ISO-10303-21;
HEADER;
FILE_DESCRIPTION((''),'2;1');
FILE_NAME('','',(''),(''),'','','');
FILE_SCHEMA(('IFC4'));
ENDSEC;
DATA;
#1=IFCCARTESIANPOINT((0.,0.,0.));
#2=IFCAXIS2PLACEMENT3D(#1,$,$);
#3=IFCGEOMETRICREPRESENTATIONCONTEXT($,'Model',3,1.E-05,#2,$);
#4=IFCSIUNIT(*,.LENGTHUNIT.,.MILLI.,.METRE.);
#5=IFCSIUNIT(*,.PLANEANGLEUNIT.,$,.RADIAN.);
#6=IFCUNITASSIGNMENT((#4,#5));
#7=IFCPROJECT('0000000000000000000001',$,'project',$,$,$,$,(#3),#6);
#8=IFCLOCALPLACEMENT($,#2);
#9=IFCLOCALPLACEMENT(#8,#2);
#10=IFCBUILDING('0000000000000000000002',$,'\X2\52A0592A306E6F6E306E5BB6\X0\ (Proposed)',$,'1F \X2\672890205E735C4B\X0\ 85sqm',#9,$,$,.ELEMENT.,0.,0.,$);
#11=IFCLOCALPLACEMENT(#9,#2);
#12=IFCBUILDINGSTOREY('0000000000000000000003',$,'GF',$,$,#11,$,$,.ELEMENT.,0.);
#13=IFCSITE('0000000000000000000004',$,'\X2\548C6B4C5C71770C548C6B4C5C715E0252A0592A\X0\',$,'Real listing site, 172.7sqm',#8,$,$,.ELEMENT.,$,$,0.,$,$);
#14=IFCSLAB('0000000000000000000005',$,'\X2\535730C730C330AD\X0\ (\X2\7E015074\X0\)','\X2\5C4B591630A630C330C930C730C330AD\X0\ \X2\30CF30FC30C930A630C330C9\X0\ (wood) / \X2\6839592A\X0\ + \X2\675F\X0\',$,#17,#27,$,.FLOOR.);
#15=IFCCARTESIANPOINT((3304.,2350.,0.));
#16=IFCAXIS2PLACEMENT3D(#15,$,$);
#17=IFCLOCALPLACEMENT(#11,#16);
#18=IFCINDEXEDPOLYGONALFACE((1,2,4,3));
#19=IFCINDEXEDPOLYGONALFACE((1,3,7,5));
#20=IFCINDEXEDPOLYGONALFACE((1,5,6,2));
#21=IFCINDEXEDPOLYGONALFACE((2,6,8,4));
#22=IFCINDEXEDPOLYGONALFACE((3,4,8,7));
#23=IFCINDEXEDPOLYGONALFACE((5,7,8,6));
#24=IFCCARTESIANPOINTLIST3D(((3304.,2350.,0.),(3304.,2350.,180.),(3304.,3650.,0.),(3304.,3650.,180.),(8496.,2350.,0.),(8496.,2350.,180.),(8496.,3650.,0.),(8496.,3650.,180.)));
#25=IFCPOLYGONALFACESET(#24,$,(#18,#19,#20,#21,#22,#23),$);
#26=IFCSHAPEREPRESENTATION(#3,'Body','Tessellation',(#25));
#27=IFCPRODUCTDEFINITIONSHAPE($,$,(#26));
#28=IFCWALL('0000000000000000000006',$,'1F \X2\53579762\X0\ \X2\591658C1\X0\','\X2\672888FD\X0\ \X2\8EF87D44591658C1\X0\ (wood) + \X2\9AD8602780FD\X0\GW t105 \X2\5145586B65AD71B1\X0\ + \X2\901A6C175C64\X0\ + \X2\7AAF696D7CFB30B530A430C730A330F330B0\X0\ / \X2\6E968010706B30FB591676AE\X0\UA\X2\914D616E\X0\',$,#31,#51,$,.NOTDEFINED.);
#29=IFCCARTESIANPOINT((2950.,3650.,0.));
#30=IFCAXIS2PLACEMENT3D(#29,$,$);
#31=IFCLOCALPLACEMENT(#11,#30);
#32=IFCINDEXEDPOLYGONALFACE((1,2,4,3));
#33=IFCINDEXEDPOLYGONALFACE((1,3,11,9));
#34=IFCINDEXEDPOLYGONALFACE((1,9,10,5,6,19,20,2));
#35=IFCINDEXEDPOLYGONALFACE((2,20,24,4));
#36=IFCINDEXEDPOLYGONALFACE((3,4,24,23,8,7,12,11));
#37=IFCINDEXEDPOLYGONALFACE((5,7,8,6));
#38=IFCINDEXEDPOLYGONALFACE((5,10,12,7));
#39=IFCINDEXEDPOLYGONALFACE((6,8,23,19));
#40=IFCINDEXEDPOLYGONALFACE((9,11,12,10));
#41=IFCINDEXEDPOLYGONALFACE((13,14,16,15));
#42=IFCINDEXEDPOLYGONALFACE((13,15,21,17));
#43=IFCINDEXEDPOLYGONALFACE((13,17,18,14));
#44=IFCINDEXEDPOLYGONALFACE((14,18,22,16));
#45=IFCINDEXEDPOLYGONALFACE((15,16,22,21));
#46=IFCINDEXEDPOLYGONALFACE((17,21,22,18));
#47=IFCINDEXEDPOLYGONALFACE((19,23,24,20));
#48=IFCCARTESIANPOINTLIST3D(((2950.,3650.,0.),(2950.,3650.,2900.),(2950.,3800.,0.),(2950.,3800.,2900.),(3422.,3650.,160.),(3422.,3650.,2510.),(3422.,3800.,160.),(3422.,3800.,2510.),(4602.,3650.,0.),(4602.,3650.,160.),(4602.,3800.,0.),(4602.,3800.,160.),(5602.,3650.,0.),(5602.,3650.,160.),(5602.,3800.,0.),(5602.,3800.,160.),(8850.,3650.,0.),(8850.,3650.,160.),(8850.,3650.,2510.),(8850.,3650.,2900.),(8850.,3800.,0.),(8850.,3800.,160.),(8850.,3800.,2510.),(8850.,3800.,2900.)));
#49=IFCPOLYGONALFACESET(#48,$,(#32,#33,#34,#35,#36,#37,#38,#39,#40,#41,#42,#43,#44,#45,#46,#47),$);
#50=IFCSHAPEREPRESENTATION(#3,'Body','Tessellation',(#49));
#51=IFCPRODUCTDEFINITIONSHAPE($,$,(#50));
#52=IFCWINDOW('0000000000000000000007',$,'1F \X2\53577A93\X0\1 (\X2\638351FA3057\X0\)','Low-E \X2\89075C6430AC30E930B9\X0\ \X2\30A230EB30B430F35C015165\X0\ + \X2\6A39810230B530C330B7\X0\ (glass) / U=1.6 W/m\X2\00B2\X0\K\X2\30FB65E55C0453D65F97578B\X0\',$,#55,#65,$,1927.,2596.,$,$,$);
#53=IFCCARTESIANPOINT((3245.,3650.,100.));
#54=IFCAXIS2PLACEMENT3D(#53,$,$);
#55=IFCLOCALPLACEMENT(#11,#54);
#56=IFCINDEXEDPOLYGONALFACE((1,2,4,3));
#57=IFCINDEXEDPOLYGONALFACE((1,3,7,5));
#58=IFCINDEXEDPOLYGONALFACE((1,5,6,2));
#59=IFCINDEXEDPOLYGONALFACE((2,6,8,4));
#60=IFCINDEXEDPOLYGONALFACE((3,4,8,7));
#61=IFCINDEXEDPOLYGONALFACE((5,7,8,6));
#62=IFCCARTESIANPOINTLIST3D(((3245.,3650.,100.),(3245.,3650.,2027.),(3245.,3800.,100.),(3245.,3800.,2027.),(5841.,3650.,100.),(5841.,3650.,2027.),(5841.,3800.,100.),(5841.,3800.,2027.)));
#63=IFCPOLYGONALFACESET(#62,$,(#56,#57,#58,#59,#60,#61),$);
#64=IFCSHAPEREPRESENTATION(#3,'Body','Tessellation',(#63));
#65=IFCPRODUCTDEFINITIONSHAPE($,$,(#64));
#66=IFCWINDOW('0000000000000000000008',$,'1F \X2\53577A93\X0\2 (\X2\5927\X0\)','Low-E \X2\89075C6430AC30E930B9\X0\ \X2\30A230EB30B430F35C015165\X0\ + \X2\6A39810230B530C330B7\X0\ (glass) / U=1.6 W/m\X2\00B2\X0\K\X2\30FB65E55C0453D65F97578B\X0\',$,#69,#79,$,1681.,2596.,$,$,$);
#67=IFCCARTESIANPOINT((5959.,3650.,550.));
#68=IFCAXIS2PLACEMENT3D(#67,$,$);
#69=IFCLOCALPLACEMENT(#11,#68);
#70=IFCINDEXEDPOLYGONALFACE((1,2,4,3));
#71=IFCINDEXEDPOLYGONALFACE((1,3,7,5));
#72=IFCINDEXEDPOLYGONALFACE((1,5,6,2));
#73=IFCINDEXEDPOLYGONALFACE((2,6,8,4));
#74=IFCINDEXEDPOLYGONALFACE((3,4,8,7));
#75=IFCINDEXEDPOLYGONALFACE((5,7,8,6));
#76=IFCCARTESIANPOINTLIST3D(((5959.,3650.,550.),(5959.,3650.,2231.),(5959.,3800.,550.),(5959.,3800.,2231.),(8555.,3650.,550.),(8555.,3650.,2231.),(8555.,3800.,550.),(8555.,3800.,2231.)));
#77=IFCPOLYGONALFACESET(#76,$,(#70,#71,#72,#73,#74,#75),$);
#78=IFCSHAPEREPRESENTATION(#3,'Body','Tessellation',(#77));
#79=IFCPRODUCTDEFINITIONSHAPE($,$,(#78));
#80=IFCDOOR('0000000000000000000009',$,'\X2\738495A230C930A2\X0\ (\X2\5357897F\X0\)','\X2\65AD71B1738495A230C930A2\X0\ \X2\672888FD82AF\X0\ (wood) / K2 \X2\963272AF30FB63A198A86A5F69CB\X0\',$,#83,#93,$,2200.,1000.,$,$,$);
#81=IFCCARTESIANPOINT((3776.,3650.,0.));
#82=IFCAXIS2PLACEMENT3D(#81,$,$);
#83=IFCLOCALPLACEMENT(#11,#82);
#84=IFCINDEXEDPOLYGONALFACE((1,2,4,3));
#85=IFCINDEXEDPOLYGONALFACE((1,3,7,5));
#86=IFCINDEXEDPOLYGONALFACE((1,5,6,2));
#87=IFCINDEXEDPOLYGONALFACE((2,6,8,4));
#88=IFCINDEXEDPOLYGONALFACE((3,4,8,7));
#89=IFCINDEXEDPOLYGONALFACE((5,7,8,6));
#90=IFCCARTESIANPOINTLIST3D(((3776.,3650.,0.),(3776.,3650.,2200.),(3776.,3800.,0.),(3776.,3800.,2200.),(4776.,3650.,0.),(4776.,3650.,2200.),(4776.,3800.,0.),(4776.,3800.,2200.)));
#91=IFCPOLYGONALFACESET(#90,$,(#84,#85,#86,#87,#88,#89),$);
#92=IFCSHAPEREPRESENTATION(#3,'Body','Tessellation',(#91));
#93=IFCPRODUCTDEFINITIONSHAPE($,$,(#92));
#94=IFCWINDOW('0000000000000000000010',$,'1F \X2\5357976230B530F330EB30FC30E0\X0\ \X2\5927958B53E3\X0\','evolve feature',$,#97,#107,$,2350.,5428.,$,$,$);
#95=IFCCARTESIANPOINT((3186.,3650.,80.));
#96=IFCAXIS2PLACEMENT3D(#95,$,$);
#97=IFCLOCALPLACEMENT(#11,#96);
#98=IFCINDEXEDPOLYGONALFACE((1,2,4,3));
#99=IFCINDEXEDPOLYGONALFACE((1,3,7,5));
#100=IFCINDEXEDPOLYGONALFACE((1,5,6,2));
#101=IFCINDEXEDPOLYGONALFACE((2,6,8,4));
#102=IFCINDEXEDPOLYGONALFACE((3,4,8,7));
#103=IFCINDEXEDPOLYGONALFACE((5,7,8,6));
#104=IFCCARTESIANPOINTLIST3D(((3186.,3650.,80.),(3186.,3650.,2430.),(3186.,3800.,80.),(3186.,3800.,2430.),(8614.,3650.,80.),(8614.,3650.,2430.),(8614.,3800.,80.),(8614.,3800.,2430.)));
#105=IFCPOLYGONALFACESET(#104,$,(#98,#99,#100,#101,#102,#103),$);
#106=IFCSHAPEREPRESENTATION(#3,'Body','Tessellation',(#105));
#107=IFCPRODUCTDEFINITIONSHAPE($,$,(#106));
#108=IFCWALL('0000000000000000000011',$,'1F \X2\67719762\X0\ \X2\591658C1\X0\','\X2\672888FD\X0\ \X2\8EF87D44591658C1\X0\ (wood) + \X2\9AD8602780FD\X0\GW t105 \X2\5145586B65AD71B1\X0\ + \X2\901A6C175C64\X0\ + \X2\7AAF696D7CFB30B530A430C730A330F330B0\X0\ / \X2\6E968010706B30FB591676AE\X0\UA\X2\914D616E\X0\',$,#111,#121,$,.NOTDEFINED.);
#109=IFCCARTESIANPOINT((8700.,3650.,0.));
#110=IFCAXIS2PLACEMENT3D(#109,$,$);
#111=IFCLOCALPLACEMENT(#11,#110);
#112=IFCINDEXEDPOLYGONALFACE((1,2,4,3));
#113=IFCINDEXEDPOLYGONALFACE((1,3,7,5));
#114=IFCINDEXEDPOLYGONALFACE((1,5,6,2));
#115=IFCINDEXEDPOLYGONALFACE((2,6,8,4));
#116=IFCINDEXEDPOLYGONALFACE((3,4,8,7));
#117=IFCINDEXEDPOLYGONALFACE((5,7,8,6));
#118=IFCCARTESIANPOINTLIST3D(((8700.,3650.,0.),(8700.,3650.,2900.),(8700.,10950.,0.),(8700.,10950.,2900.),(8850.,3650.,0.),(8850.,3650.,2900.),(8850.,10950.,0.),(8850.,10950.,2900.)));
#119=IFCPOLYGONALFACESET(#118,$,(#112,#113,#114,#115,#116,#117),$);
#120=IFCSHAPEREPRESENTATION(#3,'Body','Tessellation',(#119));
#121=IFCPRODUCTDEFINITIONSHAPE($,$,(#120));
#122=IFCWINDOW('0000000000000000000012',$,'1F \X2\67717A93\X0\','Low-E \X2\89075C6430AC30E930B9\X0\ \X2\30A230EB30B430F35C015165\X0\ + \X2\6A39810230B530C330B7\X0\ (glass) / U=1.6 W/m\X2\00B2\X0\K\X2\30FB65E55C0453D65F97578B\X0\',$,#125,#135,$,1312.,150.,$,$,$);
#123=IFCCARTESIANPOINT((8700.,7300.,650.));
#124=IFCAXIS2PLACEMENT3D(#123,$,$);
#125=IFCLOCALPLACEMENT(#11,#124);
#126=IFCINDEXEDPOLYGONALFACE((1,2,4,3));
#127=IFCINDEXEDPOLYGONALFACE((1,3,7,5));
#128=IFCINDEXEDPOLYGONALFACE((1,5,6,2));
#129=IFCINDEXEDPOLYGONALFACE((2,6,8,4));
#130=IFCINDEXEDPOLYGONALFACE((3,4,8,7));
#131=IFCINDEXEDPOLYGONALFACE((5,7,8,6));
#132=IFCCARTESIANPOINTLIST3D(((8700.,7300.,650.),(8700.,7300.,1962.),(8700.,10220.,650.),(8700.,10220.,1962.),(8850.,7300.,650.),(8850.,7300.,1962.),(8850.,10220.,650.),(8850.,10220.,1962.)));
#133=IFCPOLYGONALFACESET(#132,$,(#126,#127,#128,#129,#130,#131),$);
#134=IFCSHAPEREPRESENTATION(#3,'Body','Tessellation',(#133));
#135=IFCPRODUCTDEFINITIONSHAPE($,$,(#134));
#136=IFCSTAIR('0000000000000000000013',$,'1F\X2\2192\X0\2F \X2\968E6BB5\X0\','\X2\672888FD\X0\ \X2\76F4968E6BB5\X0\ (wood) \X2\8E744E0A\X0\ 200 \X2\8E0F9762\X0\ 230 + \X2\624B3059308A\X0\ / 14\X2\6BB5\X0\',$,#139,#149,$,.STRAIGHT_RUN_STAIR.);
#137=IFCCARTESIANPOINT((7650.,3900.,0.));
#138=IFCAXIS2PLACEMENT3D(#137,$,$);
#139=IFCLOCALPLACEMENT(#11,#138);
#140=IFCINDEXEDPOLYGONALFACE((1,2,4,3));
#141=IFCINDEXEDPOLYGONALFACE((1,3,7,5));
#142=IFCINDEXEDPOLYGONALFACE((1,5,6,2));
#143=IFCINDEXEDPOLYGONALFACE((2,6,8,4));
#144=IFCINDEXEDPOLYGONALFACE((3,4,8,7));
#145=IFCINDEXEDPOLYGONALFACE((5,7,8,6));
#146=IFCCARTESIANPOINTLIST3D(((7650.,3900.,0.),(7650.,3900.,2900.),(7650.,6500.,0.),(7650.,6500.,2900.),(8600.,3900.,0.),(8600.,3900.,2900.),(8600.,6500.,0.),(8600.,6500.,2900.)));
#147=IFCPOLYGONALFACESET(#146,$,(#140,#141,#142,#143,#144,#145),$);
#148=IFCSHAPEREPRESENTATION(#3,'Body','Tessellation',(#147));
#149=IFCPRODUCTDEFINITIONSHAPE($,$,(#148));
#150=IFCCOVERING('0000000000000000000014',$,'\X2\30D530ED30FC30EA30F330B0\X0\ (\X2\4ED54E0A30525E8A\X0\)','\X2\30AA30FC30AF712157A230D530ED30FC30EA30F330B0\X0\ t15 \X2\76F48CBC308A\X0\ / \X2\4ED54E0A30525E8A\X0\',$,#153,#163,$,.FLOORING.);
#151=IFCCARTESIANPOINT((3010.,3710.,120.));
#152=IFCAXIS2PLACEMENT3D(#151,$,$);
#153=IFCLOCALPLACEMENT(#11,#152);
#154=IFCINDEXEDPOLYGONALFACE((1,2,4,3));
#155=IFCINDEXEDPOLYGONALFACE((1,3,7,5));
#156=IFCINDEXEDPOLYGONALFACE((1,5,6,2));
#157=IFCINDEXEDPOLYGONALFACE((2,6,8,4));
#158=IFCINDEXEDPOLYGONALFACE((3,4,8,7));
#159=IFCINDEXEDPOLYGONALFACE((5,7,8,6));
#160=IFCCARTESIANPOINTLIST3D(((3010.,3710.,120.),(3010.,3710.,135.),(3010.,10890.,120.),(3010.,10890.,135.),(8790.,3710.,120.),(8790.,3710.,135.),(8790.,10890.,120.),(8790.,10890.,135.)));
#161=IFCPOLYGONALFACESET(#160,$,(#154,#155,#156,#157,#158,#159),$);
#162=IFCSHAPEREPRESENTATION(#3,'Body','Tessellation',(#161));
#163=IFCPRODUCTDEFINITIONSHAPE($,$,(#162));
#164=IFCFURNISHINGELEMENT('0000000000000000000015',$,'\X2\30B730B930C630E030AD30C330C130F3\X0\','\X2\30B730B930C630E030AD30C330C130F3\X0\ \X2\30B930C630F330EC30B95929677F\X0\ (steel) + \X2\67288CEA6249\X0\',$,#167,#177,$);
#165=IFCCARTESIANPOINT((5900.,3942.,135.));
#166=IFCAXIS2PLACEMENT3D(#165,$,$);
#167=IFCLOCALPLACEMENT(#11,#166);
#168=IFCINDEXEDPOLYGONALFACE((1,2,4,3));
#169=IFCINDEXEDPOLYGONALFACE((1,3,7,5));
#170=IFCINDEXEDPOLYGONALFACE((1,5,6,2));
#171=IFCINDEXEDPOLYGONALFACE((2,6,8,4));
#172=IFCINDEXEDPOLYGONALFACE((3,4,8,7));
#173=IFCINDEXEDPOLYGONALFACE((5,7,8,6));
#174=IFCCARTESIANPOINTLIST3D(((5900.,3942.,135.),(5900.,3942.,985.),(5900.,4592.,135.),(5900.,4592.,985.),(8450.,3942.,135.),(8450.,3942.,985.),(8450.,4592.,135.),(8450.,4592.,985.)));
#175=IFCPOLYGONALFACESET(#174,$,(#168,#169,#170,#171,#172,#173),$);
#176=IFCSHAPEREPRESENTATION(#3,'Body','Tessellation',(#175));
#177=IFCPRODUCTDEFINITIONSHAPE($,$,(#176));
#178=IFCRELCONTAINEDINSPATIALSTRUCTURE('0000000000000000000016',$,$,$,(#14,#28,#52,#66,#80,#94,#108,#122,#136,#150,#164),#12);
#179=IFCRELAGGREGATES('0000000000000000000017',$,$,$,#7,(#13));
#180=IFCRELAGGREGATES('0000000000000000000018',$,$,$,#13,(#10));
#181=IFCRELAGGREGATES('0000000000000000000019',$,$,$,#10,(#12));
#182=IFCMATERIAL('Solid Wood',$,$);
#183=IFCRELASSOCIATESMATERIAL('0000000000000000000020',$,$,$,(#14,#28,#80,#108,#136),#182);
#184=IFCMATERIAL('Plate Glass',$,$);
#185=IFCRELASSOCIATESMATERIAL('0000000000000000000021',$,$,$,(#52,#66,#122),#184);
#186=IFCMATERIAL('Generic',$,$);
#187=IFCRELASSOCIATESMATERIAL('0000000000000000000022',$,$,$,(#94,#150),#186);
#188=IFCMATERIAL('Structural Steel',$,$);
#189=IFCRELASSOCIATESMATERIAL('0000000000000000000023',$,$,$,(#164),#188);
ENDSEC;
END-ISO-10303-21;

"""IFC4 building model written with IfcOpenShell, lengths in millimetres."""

from ifc_helpers import new_model, si_unit, frame, frame_2d, origin, place, context, project, spatial, rectangle, extrude, material, element, fill, save


model = new_model("IFC4")

# Units and contexts
model_context = context("Model", 3, precision=1e-05, world=origin())
ifc_project = project(units=[si_unit("LENGTHUNIT", "METRE", prefix="MILLI"), si_unit("PLANEANGLEUNIT", "RADIAN")], contexts=[model_context])

# Site, building, storey
site_placement = place(None, origin())
site = spatial("IfcSite", under=ifc_project, at=site_placement, Name="和歌山県和歌山市加太", ObjectType="Real listing site, 172.7sqm", CompositionType="ELEMENT", RefElevation=0.0)
building_placement = place(site_placement, origin())
building = spatial("IfcBuilding", under=site, at=building_placement, Name="加太の潮の家 (Proposed)", ObjectType="1F 木造平屋 85sqm", CompositionType="ELEMENT", ElevationOfRefHeight=0.0, ElevationOfTerrain=0.0)
storey_placement = place(building_placement, origin())
storey = spatial("IfcBuildingStorey", under=building, at=storey_placement, Name="GF", CompositionType="ELEMENT", Elevation=0.0)

# Slab
ifc_material_1 = material(Name="Solid Wood")
slab_1_placement = place(storey_placement, frame((3304.0, 2350.0, 0.0)))
element("IfcSlab", 1, at=slab_1_placement, inside=storey, material=ifc_material_1, Name="南デッキ (縁側)", Description="屋外ウッドデッキ ハードウッド (wood) / 根太 + 束", PredefinedType="FLOOR", context=model_context, shape_type="SweptSolid", body=[
    extrude(rectangle(XDim=5192.0, YDim=1300.0, at=frame_2d((2596.0, 650.0))), frame((3304.0, 2350.0, 0.0)), (0.0, 0.0, 1.0), 180.0),
])
ifc_material_2 = material(Name="Generic")

# Wall, openings, windows, door
wall_1_placement = place(storey_placement, frame((2950.0, 3650.0, 0.0)))
wall_1 = element("IfcWall", 2, at=wall_1_placement, inside=storey, material=ifc_material_1, Name="1F 南面 外壁", Description="木製 軸組外壁 (wood) + 高性能GW t105 充填断熱 + 通気層 + 窯業系サイディング / 準耐火・外皮UA配慮", PredefinedType="NOTDEFINED", context=model_context, shape_type="SweptSolid", body=[
    extrude(rectangle(XDim=5900.0, YDim=150.0, at=frame_2d((2950.0, 75.0))), frame((2950.0, 3650.0, 0.0)), (0.0, 0.0, 1.0), 2900.0),
])
opening_1_placement = place(storey_placement, frame((3245.0, 3650.0, 100.0)))
opening_1 = element("IfcOpeningElement", 3, at=opening_1_placement, cuts=wall_1, PredefinedType="NOTDEFINED", context=model_context, shape_type="SweptSolid", body=[
    extrude(rectangle(XDim=2596.0, YDim=150.0, at=frame_2d((1298.0, 75.0))), frame((3245.0, 3650.0, 100.0)), (0.0, 0.0, 1.0), 1927.0),
])
opening_2_placement = place(storey_placement, frame((5959.0, 3650.0, 550.0)))
opening_2 = element("IfcOpeningElement", 4, at=opening_2_placement, cuts=wall_1, PredefinedType="NOTDEFINED", context=model_context, shape_type="SweptSolid", body=[
    extrude(rectangle(XDim=2596.0, YDim=150.0, at=frame_2d((1298.0, 75.0))), frame((5959.0, 3650.0, 550.0)), (0.0, 0.0, 1.0), 1681.0),
])
opening_3_placement = place(storey_placement, frame((3776.0, 3650.0, 0.0)))
opening_3 = element("IfcOpeningElement", 5, at=opening_3_placement, cuts=wall_1, PredefinedType="NOTDEFINED", context=model_context, shape_type="SweptSolid", body=[
    extrude(rectangle(XDim=1000.0, YDim=150.0, at=frame_2d((500.0, 75.0))), frame((3776.0, 3650.0, 0.0)), (0.0, 0.0, 1.0), 2200.0),
])
opening_4_placement = place(storey_placement, frame((3186.0, 3650.0, 80.0)))
opening_4 = element("IfcOpeningElement", 6, at=opening_4_placement, cuts=wall_1, PredefinedType="NOTDEFINED", context=model_context, shape_type="SweptSolid", body=[
    extrude(rectangle(XDim=5428.0, YDim=150.0, at=frame_2d((2714.0, 75.0))), frame((3186.0, 3650.0, 80.0)), (0.0, 0.0, 1.0), 2350.0),
])
ifc_material_3 = material(Name="Plate Glass")
window_1_placement = place(storey_placement, frame((3245.0, 3650.0, 100.0)))
window_1 = element("IfcWindow", 7, at=window_1_placement, inside=storey, material=ifc_material_3, Name="1F 南窓1 (掃出し)", Description="Low-E 複層ガラス アルゴン封入 + 樹脂サッシ (glass) / U=1.6 W/m²K・日射取得型", OverallHeight=1927.0, OverallWidth=2596.0, context=model_context, shape_type="SweptSolid", body=[
    extrude(rectangle(XDim=2596.0, YDim=150.0, at=frame_2d((1298.0, 75.0))), frame((3245.0, 3650.0, 100.0)), (0.0, 0.0, 1.0), 1927.0),
])
fill(opening_1, window_1)
window_2_placement = place(storey_placement, frame((5959.0, 3650.0, 550.0)))
window_2 = element("IfcWindow", 8, at=window_2_placement, inside=storey, material=ifc_material_3, Name="1F 南窓2 (大)", Description="Low-E 複層ガラス アルゴン封入 + 樹脂サッシ (glass) / U=1.6 W/m²K・日射取得型", OverallHeight=1681.0, OverallWidth=2596.0, context=model_context, shape_type="SweptSolid", body=[
    extrude(rectangle(XDim=2596.0, YDim=150.0, at=frame_2d((1298.0, 75.0))), frame((5959.0, 3650.0, 550.0)), (0.0, 0.0, 1.0), 1681.0),
])
fill(opening_2, window_2)
door_placement = place(storey_placement, frame((3776.0, 3650.0, 0.0)))
door = element("IfcDoor", 9, at=door_placement, inside=storey, material=ifc_material_1, Name="玄関ドア (南西)", Description="断熱玄関ドア 木製芯 (wood) / K2 防犯・採風機構", OverallHeight=2200.0, OverallWidth=1000.0, context=model_context, shape_type="SweptSolid", body=[
    extrude(rectangle(XDim=1000.0, YDim=150.0, at=frame_2d((500.0, 75.0))), frame((3776.0, 3650.0, 0.0)), (0.0, 0.0, 1.0), 2200.0),
])
fill(opening_3, door)
window_3_placement = place(storey_placement, frame((3186.0, 3650.0, 80.0)))
window_3 = element("IfcWindow", 10, at=window_3_placement, inside=storey, material=ifc_material_2, Name="1F 南面サンルーム 大開口", Description="evolve feature", OverallHeight=2350.0, OverallWidth=5428.0, context=model_context, shape_type="SweptSolid", body=[
    extrude(rectangle(XDim=5428.0, YDim=150.0, at=frame_2d((2714.0, 75.0))), frame((3186.0, 3650.0, 80.0)), (0.0, 0.0, 1.0), 2350.0),
])
fill(opening_4, window_3)

# Wall, opening, window
wall_2_placement = place(storey_placement, frame((8700.0, 3650.0, 0.0)))
wall_2 = element("IfcWall", 11, at=wall_2_placement, inside=storey, material=ifc_material_1, Name="1F 東面 外壁", Description="木製 軸組外壁 (wood) + 高性能GW t105 充填断熱 + 通気層 + 窯業系サイディング / 準耐火・外皮UA配慮", PredefinedType="NOTDEFINED", context=model_context, shape_type="SweptSolid", body=[
    extrude(rectangle(XDim=150.0, YDim=7300.0, at=frame_2d((75.0, 3650.0))), frame((8700.0, 3650.0, 0.0)), (0.0, 0.0, 1.0), 2900.0),
])
opening_5_placement = place(storey_placement, frame((8700.0, 7300.0, 650.0)))
opening_5 = element("IfcOpeningElement", 12, at=opening_5_placement, cuts=wall_2, PredefinedType="NOTDEFINED", context=model_context, shape_type="SweptSolid", body=[
    extrude(rectangle(XDim=150.0, YDim=2920.0, at=frame_2d((75.0, 1460.0))), frame((8700.0, 7300.0, 650.0)), (0.0, 0.0, 1.0), 1312.0),
])
window_4_placement = place(storey_placement, frame((8700.0, 7300.0, 650.0)))
window_4 = element("IfcWindow", 13, at=window_4_placement, inside=storey, material=ifc_material_3, Name="1F 東窓", Description="Low-E 複層ガラス アルゴン封入 + 樹脂サッシ (glass) / U=1.6 W/m²K・日射取得型", OverallHeight=1312.0, OverallWidth=150.0, context=model_context, shape_type="SweptSolid", body=[
    extrude(rectangle(XDim=150.0, YDim=2920.0, at=frame_2d((75.0, 1460.0))), frame((8700.0, 7300.0, 650.0)), (0.0, 0.0, 1.0), 1312.0),
])
fill(opening_5, window_4)

# Stair
stair_placement = place(storey_placement, frame((7650.0, 3900.0, 0.0)))
element("IfcStair", 14, at=stair_placement, inside=storey, material=ifc_material_1, Name="1F→2F 階段", Description="木製 直階段 (wood) 蹴上 200 踏面 230 + 手すり / 14段", PredefinedType="STRAIGHT_RUN_STAIR", context=model_context, shape_type="SweptSolid", body=[
    extrude(rectangle(XDim=950.0, YDim=2600.0, at=frame_2d((475.0, 1300.0))), frame((7650.0, 3900.0, 0.0)), (0.0, 0.0, 1.0), 2900.0),
])

# Covering
covering_placement = place(storey_placement, frame((3010.0, 3710.0, 120.0)))
element("IfcCovering", 15, at=covering_placement, inside=storey, material=ifc_material_2, Name="フローリング (仕上げ床)", Description="オーク無垢フローリング t15 直貼り / 仕上げ床", PredefinedType="FLOORING", context=model_context, shape_type="SweptSolid", body=[
    extrude(rectangle(XDim=5780.0, YDim=7180.0, at=frame_2d((2890.0, 3590.0))), frame((3010.0, 3710.0, 120.0)), (0.0, 0.0, 1.0), 15.0),
])

# Furnishing element
ifc_material_4 = material(Name="Structural Steel")
furnishing_placement = place(storey_placement, frame((5900.0, 3942.0, 135.0)))
element("IfcFurnishingElement", 16, at=furnishing_placement, inside=storey, material=ifc_material_4, Name="システムキッチン", Description="システムキッチン ステンレス天板 (steel) + 木質扉", context=model_context, shape_type="SweptSolid", body=[
    extrude(rectangle(XDim=2550.0, YDim=650.0, at=frame_2d((1275.0, 325.0))), frame((5900.0, 3942.0, 135.0)), (0.0, 0.0, 1.0), 850.0),
])

save(model, "model.ifc")
